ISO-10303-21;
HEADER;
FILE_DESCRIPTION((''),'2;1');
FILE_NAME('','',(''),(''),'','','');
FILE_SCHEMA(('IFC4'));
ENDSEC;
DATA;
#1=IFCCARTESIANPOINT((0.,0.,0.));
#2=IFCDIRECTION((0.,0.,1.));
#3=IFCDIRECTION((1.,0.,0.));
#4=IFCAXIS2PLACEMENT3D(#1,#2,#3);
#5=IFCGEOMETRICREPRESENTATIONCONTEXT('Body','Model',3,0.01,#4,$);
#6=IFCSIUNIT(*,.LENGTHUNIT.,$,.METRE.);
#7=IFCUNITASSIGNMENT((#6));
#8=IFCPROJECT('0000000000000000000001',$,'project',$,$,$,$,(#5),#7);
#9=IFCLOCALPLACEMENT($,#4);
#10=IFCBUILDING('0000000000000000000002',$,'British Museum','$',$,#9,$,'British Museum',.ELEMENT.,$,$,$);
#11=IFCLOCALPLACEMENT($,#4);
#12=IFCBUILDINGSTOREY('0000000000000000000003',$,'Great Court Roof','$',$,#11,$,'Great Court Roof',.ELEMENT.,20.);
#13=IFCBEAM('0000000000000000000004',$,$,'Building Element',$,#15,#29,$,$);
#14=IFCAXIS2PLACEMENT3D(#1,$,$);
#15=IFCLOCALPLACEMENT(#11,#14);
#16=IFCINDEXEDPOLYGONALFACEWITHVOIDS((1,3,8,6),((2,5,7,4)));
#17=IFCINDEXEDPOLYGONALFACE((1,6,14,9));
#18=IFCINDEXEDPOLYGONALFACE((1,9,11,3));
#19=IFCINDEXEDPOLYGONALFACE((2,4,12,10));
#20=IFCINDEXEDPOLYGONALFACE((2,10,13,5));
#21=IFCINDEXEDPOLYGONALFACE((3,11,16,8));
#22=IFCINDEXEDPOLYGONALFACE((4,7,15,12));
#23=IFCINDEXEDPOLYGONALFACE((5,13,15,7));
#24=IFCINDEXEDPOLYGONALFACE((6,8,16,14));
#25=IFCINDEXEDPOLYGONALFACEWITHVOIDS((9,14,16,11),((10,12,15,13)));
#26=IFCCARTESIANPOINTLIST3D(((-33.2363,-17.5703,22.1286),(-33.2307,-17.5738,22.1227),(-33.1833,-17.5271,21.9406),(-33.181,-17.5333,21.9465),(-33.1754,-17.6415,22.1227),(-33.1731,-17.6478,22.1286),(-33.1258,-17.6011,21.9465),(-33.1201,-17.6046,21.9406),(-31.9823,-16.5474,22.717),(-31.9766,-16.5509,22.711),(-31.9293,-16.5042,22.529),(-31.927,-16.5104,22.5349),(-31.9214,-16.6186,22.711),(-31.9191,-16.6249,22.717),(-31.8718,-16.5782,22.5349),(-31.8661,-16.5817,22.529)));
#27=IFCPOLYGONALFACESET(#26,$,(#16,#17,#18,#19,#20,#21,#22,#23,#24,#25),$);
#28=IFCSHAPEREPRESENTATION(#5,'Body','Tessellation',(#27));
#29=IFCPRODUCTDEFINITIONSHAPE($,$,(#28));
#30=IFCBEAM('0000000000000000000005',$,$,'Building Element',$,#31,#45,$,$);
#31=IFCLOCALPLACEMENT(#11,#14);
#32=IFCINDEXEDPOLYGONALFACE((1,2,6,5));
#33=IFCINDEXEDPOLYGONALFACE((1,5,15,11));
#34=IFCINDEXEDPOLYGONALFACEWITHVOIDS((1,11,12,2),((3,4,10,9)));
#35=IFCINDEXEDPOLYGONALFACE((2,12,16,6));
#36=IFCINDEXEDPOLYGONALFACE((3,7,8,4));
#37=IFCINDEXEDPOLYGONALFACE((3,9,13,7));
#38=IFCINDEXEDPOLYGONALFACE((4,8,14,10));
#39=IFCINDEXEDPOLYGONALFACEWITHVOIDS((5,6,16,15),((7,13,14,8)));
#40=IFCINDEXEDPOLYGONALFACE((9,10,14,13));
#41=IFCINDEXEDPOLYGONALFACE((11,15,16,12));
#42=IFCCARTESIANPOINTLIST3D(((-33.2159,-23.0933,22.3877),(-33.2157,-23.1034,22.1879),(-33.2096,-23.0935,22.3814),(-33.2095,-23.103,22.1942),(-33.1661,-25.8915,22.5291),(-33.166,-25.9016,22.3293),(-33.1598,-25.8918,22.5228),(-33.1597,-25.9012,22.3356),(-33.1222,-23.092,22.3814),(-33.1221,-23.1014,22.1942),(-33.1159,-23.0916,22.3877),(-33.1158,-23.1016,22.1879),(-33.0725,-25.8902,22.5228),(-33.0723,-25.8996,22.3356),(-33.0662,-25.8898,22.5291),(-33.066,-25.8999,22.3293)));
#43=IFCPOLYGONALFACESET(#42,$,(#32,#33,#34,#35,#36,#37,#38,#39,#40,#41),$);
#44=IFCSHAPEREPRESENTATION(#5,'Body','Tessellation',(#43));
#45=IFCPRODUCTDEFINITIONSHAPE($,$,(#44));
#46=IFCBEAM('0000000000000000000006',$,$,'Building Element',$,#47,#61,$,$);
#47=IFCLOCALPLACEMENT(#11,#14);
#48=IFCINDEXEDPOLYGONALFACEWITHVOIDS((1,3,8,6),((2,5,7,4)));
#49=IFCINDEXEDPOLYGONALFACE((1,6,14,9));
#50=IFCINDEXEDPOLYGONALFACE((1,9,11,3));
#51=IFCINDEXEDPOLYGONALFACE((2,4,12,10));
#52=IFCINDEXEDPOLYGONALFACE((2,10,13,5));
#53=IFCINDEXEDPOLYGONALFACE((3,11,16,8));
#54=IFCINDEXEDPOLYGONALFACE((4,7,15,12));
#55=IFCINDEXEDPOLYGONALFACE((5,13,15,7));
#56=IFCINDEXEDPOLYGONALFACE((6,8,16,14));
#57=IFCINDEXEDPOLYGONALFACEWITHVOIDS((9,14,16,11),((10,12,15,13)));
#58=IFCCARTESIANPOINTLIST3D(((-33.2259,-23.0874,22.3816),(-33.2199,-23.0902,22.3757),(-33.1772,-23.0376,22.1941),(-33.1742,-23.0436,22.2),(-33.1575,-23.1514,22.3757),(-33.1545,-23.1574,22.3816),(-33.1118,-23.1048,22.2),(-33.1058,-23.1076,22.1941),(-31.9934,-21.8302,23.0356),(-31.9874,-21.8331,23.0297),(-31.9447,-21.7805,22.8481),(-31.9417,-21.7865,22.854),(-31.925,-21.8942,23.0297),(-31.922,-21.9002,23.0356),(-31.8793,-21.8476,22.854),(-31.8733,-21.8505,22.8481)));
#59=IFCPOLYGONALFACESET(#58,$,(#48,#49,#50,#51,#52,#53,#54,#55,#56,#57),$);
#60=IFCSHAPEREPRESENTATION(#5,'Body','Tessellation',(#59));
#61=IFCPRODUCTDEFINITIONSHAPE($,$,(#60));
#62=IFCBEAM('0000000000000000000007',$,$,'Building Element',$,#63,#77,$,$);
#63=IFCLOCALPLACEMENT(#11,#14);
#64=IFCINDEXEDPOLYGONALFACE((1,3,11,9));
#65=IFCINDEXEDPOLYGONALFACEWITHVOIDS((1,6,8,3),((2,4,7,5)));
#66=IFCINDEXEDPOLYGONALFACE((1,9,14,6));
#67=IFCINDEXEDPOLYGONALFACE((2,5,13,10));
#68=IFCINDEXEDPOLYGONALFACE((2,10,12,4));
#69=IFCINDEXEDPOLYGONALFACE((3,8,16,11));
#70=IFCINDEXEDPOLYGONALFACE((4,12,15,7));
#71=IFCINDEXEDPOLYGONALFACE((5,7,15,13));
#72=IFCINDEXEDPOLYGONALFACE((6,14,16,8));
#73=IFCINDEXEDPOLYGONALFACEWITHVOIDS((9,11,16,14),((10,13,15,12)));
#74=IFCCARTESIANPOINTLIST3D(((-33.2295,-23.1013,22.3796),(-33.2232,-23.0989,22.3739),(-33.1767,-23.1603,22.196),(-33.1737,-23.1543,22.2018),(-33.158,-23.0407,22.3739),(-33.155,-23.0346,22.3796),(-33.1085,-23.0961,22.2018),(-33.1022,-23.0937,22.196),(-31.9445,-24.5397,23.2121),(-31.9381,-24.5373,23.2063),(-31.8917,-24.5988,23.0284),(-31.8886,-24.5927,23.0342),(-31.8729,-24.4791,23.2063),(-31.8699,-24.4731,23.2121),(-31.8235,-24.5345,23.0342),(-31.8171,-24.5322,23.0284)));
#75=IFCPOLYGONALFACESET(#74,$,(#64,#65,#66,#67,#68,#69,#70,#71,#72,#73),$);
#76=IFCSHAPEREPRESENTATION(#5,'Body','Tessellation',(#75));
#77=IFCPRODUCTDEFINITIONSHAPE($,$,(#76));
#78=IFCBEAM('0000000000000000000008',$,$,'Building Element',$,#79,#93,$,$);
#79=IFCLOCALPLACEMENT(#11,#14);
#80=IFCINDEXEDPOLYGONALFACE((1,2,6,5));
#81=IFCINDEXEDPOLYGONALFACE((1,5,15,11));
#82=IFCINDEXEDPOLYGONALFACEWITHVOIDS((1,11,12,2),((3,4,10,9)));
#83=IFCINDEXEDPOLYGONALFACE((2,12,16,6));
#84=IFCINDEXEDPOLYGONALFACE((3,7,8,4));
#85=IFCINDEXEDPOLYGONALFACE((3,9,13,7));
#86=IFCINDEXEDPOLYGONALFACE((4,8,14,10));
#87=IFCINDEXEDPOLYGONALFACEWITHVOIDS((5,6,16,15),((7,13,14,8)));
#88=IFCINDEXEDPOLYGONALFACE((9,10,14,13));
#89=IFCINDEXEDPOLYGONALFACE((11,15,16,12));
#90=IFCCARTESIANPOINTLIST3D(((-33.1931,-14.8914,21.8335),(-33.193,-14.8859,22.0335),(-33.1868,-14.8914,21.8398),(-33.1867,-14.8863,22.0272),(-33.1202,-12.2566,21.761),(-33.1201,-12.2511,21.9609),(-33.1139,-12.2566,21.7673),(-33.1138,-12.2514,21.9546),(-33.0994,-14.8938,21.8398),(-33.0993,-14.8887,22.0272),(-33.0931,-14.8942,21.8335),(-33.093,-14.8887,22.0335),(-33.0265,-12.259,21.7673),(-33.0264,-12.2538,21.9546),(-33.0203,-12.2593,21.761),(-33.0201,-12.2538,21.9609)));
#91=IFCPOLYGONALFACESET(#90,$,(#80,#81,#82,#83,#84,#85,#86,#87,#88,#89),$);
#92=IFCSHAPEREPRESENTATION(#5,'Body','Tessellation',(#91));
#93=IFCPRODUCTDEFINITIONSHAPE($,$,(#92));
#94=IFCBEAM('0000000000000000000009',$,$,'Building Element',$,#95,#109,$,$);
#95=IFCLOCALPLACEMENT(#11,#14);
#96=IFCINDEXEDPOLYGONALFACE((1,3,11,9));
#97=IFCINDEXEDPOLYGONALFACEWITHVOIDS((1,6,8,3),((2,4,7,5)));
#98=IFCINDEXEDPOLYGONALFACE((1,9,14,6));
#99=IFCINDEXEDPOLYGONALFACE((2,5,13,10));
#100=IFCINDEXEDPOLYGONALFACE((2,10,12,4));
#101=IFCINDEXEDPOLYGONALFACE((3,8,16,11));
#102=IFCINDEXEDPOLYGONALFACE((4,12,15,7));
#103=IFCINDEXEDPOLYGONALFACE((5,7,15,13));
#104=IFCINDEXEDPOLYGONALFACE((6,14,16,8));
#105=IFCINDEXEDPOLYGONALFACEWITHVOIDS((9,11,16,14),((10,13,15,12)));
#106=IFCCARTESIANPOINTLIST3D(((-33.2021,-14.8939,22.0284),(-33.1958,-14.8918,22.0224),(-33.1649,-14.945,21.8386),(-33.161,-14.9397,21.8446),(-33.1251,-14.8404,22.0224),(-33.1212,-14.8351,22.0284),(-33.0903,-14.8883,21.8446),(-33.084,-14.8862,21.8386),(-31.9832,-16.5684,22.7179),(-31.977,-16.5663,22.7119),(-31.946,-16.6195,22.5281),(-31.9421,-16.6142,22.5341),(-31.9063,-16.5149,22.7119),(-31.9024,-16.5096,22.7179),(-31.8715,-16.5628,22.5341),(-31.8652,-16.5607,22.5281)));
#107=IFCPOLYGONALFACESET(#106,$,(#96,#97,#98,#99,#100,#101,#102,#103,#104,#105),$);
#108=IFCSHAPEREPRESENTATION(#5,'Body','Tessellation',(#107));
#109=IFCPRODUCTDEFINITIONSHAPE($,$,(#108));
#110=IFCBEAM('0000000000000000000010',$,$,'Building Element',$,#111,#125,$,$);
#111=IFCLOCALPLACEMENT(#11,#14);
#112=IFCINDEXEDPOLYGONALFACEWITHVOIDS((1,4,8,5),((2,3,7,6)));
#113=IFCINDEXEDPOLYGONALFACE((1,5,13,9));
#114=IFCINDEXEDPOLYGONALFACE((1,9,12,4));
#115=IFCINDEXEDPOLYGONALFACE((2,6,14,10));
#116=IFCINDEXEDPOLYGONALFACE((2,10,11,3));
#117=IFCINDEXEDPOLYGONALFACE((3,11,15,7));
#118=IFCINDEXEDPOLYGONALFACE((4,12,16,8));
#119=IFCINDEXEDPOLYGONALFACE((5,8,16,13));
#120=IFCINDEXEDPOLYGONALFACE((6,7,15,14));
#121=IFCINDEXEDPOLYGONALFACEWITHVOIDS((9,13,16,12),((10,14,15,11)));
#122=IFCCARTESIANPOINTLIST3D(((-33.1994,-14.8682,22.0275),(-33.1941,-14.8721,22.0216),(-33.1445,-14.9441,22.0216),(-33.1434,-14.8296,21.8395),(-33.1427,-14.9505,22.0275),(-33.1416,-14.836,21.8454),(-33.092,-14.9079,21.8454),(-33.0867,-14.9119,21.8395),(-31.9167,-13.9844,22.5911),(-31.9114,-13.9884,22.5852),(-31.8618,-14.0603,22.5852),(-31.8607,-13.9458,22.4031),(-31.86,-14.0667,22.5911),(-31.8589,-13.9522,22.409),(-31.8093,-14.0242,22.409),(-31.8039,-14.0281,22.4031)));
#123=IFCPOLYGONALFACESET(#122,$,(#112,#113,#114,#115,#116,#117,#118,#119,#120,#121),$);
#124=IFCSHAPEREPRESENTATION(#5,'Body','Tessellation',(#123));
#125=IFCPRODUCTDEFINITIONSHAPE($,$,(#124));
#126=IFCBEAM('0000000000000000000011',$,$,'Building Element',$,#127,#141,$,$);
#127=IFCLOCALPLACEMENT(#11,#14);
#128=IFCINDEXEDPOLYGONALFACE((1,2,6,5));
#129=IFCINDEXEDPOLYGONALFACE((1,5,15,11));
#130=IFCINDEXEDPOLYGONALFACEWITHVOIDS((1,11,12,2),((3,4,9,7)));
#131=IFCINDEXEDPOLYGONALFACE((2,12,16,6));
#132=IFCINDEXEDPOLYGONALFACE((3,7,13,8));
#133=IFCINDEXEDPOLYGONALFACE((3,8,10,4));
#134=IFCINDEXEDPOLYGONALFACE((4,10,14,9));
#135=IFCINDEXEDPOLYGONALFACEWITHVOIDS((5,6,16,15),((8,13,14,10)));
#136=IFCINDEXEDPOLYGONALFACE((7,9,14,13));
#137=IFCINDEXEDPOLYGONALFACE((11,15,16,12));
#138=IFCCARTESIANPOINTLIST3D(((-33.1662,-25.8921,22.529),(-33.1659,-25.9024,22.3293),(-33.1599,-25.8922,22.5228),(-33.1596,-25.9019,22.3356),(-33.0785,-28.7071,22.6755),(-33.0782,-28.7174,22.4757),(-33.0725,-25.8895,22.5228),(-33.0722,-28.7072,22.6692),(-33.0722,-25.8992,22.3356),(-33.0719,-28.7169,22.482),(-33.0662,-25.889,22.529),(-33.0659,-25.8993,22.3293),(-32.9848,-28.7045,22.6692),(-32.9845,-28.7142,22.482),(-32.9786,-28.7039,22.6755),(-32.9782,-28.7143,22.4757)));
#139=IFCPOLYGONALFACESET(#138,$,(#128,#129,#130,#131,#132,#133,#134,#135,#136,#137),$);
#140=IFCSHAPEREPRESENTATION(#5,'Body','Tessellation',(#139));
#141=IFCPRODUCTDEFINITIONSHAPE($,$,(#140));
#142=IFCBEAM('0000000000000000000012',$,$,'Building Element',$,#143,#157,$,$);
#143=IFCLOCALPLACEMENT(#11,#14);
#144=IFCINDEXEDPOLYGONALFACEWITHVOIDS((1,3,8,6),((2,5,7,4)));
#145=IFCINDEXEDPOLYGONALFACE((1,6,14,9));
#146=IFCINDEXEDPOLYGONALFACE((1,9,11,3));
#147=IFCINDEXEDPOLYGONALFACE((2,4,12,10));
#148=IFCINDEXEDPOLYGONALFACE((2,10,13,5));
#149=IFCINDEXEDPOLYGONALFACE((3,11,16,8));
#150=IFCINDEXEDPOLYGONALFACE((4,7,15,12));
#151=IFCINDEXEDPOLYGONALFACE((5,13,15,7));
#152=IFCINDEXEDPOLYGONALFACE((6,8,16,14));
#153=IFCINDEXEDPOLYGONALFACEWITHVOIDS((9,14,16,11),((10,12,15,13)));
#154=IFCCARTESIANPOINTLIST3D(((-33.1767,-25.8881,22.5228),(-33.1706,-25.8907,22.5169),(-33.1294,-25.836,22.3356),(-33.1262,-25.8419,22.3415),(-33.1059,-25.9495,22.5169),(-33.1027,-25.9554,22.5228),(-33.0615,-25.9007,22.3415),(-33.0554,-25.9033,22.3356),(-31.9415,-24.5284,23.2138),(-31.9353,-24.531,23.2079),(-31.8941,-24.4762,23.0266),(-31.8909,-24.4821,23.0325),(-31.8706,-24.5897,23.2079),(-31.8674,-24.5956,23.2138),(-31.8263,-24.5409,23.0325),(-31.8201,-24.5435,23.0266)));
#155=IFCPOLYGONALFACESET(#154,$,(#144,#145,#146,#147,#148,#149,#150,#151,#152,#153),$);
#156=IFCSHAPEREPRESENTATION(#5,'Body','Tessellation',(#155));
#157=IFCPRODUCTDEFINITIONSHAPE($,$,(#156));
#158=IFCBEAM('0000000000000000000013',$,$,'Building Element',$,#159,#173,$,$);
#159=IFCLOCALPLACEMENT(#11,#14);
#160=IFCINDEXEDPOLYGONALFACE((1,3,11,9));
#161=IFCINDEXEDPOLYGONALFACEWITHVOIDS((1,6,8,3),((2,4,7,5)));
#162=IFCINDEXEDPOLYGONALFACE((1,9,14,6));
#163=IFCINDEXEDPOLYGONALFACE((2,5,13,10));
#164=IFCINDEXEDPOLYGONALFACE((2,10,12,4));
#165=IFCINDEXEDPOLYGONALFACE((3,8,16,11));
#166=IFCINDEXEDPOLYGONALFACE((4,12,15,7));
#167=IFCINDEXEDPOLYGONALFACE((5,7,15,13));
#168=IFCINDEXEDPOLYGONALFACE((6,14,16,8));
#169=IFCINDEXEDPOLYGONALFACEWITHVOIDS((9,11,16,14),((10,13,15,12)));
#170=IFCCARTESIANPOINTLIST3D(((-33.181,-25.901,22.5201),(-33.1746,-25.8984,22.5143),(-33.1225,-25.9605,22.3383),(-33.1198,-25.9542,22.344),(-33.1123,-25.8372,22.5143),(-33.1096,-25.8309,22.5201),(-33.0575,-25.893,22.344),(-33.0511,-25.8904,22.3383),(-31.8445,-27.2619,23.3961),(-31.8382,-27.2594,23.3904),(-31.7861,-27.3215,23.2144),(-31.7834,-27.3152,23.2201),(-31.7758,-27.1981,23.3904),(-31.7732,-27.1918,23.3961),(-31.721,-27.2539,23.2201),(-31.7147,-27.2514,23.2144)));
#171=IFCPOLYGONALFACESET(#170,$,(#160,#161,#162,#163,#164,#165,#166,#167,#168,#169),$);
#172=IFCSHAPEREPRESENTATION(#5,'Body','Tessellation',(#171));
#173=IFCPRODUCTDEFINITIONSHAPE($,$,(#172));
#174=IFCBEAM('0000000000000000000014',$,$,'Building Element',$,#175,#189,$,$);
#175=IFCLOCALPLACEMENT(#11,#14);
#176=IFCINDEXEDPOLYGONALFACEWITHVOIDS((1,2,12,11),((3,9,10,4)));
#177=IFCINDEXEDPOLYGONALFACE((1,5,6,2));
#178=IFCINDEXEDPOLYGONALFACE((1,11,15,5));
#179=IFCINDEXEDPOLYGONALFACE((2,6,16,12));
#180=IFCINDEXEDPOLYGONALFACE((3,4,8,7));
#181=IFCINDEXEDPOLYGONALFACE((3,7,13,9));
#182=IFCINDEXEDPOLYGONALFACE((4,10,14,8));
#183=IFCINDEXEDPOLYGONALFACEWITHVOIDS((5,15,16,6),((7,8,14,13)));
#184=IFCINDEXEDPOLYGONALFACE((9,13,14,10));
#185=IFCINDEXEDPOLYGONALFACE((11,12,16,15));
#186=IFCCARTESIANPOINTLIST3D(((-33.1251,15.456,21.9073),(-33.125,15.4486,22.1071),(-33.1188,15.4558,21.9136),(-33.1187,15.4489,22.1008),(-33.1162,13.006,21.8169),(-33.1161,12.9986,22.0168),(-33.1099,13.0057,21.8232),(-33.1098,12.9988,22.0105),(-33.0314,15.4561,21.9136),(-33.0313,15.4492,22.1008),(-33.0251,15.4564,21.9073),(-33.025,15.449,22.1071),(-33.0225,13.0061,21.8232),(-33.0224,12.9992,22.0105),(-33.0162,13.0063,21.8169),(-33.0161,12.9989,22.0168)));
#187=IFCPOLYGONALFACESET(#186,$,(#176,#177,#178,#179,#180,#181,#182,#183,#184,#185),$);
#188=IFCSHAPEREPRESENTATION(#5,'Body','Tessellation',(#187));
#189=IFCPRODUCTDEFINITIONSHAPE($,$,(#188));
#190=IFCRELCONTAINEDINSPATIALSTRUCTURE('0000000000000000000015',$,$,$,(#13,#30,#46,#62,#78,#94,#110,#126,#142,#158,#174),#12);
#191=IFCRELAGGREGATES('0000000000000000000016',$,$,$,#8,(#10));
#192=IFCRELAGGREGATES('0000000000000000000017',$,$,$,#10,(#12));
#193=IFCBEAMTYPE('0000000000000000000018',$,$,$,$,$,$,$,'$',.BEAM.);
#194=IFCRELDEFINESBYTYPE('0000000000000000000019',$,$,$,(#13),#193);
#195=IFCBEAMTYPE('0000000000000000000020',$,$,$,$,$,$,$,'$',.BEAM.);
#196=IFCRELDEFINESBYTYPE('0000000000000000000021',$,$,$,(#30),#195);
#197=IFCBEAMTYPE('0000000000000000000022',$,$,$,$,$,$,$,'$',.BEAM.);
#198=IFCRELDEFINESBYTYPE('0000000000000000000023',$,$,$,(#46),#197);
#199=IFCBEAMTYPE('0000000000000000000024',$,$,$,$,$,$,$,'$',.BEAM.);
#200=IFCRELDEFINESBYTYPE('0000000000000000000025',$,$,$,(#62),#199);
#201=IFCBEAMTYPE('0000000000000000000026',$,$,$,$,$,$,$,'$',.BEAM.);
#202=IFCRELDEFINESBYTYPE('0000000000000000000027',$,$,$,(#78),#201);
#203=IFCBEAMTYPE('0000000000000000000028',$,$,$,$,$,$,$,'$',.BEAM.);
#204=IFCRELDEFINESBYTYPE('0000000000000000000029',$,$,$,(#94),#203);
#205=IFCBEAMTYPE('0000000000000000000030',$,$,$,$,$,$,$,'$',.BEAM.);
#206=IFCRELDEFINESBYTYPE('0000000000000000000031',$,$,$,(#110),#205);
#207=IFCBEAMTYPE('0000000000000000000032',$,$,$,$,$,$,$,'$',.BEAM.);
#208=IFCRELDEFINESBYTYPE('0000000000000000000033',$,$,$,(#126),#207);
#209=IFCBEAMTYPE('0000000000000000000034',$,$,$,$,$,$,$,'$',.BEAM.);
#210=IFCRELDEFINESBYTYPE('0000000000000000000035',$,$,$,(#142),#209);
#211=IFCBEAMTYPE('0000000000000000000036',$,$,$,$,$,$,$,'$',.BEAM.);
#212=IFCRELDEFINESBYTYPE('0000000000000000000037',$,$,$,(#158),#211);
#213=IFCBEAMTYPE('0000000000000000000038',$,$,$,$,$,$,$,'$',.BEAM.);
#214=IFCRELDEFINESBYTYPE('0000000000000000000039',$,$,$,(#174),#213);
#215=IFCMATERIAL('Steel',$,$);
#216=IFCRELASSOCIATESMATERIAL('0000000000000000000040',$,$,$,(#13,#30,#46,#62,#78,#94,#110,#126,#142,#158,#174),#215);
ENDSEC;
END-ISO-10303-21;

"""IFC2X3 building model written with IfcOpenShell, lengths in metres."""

from ifc_helpers import new_model, si_unit, frame, origin_with_axes, origin_2d, place, context, project, spatial, hollow_rectangle, extrude, material, type_object, element, save


model = new_model("IFC2X3")

# Units and contexts
model_context = context("Model", 3, precision=0.01, world=origin_with_axes(), identifier="Body")
ifc_project = project(units=[si_unit("LENGTHUNIT", "METRE")], contexts=[model_context])

# Building, storey
building_placement = place(None, origin_with_axes())
building = spatial("IfcBuilding", under=ifc_project, at=building_placement, Name="British Museum", Description="$", LongName="British Museum", CompositionType="ELEMENT")
storey_placement = place(None, origin_with_axes())
storey = spatial("IfcBuildingStorey", under=building, at=storey_placement, Name="Great Court Roof", Description="$", LongName="Great Court Roof", CompositionType="ELEMENT", Elevation=20.0)

# Beams
ifc_material = material(Name="Steel")
beam_type_1 = type_object("IfcBeamType", ElementType="$", PredefinedType="BEAM")
beam_1_placement = place(None, origin_with_axes())
element("IfcBeam", 1, at=beam_1_placement, inside=storey, type_object=beam_type_1, material=ifc_material, Description="Building Element", context=model_context, shape_type="SweptSolid", body=[
    extrude(hollow_rectangle(XDim=0.1, YDim=0.2, WallThickness=0.0063, InnerFilletRadius=0.0, OuterFilletRadius=0.0, at=origin_2d()), frame((-33.1782, -17.5874, 22.0346), z_axis=(0.728256, 0.594044, 0.341693), x_axis=(-0.632089, 0.774896, 0.0)), (0.0, 0.0, 1.0), 1.7219),
])
beam_type_2 = type_object("IfcBeamType", ElementType="$", PredefinedType="BEAM")
beam_2_placement = place(None, origin_with_axes())
element("IfcBeam", 2, at=beam_2_placement, inside=storey, type_object=beam_type_2, material=ifc_material, Description="Building Element", context=model_context, shape_type="SweptSolid", body=[
    extrude(hollow_rectangle(XDim=0.1, YDim=0.2, WallThickness=0.0063, InnerFilletRadius=0.0, OuterFilletRadius=0.0, at=origin_2d()), frame((-33.1658, -23.0975, 22.2878), z_axis=(0.017765, -0.998569, 0.050446), x_axis=(0.999842, 0.017788, 0.0)), (0.0, 0.0, 1.0), 2.8022),
])
beam_type_3 = type_object("IfcBeamType", ElementType="$", PredefinedType="BEAM")
beam_3_placement = place(None, origin_with_axes())
element("IfcBeam", 3, at=beam_3_placement, inside=storey, type_object=beam_type_3, material=ifc_material, Description="Building Element", context=model_context, shape_type="SweptSolid", body=[
    extrude(hollow_rectangle(XDim=0.1, YDim=0.2, WallThickness=0.0063, InnerFilletRadius=0.0, OuterFilletRadius=0.0, at=origin_2d()), frame((-33.1658, -23.0975, 22.2878), z_axis=(0.656247, 0.669371, 0.348256), x_axis=(-0.714072, 0.700072, 0.0)), (0.0, 0.0, 1.0), 1.8781),
])
beam_type_4 = type_object("IfcBeamType", ElementType="$", PredefinedType="BEAM")
beam_4_placement = place(None, origin_with_axes())
element("IfcBeam", 4, at=beam_4_placement, inside=storey, type_object=beam_type_4, material=ifc_material, Description="Building Element", context=model_context, shape_type="SweptSolid", body=[
    extrude(hollow_rectangle(XDim=0.1, YDim=0.2, WallThickness=0.0063, InnerFilletRadius=0.0, OuterFilletRadius=0.0, at=origin_2d()), frame((-33.1658, -23.0975, 22.2878), z_axis=(0.611699, -0.684703, 0.396239), x_axis=(0.745745, 0.666232, 0.0)), (0.0, 0.0, 1.0), 2.1008),
])
beam_type_5 = type_object("IfcBeamType", ElementType="$", PredefinedType="BEAM")
beam_5_placement = place(None, origin_with_axes())
element("IfcBeam", 5, at=beam_5_placement, inside=storey, type_object=beam_type_5, material=ifc_material, Description="Building Element", context=model_context, shape_type="SweptSolid", body=[
    extrude(hollow_rectangle(XDim=0.1, YDim=0.2, WallThickness=0.0063, InnerFilletRadius=0.0, OuterFilletRadius=0.0, at=origin_2d()), frame((-33.143, -14.89, 21.9335), z_axis=(0.027642, 0.999239, -0.027509), x_axis=(-0.999618, 0.027652, 0.0)), (0.0, 0.0, 1.0), 2.6369),
])
beam_type_6 = type_object("IfcBeamType", ElementType="$", PredefinedType="BEAM")
beam_6_placement = place(None, origin_with_axes())
element("IfcBeam", 6, at=beam_6_placement, inside=storey, type_object=beam_type_6, material=ifc_material, Description="Building Element", context=model_context, shape_type="SweptSolid", body=[
    extrude(hollow_rectangle(XDim=0.1, YDim=0.2, WallThickness=0.0063, InnerFilletRadius=0.0, OuterFilletRadius=0.0, at=origin_2d()), frame((-33.143, -14.89, 21.9335), z_axis=(0.558367, -0.767113, 0.315856), x_axis=(0.808502, 0.588493, 0.0)), (0.0, 0.0, 1.0), 2.1829),
])
beam_type_7 = type_object("IfcBeamType", ElementType="$", PredefinedType="BEAM")
beam_7_placement = place(None, origin_with_axes())
element("IfcBeam", 7, at=beam_7_placement, inside=storey, type_object=beam_type_7, material=ifc_material, Description="Building Element", context=model_context, shape_type="SweptSolid", body=[
    extrude(hollow_rectangle(XDim=0.1, YDim=0.2, WallThickness=0.0063, InnerFilletRadius=0.0, OuterFilletRadius=0.0, at=origin_2d()), frame((-33.143, -14.89, 21.9335), z_axis=(0.774351, 0.53351, 0.340216), x_axis=(-0.567355, 0.823474, 0.0)), (0.0, 0.0, 1.0), 1.6565),
])
beam_type_8 = type_object("IfcBeamType", ElementType="$", PredefinedType="BEAM")
beam_8_placement = place(None, origin_with_axes())
element("IfcBeam", 8, at=beam_8_placement, inside=storey, type_object=beam_type_8, material=ifc_material, Description="Building Element", context=model_context, shape_type="SweptSolid", body=[
    extrude(hollow_rectangle(XDim=0.1, YDim=0.2, WallThickness=0.0063, InnerFilletRadius=0.0, OuterFilletRadius=0.0, at=origin_2d()), frame((-33.1161, -25.8957, 22.4292), z_axis=(0.031096, -0.998167, 0.051915), x_axis=(0.999515, 0.031138, 0.0)), (0.0, 0.0, 1.0), 2.8202),
])
beam_type_9 = type_object("IfcBeamType", ElementType="$", PredefinedType="BEAM")
beam_9_placement = place(None, origin_with_axes())
element("IfcBeam", 9, at=beam_9_placement, inside=storey, type_object=beam_type_9, material=ifc_material, Description="Building Element", context=model_context, shape_type="SweptSolid", body=[
    extrude(hollow_rectangle(XDim=0.1, YDim=0.2, WallThickness=0.0063, InnerFilletRadius=0.0, OuterFilletRadius=0.0, at=origin_2d()), frame((-33.1161, -25.8957, 22.4292), z_axis=(0.629355, 0.692783, 0.352084), x_axis=(-0.740178, 0.672411, 0.0)), (0.0, 0.0, 1.0), 1.9628),
])
beam_type_10 = type_object("IfcBeamType", ElementType="$", PredefinedType="BEAM")
beam_10_placement = place(None, origin_with_axes())
element("IfcBeam", 10, at=beam_10_placement, inside=storey, type_object=beam_type_10, material=ifc_material, Description="Building Element", context=model_context, shape_type="SweptSolid", body=[
    extrude(hollow_rectangle(XDim=0.1, YDim=0.2, WallThickness=0.0063, InnerFilletRadius=0.0, OuterFilletRadius=0.0, at=origin_2d()), frame((-33.1161, -25.8957, 22.4292), z_axis=(0.636709, -0.648385, 0.41737), x_axis=(0.713502, 0.700653, 0.0)), (0.0, 0.0, 1.0), 2.099),
])
beam_type_11 = type_object("IfcBeamType", ElementType="$", PredefinedType="BEAM")
beam_11_placement = place(None, origin_with_axes())
element("IfcBeam", 11, at=beam_11_placement, inside=storey, type_object=beam_type_11, material=ifc_material, Description="Building Element", context=model_context, shape_type="SweptSolid", body=[
    extrude(hollow_rectangle(XDim=0.1, YDim=0.2, WallThickness=0.0063, InnerFilletRadius=0.0, OuterFilletRadius=0.0, at=origin_2d()), frame((-33.0751, 15.4525, 22.0072), z_axis=(0.00363, -0.999314, -0.036854), x_axis=(0.999993, 0.003633, 0.0)), (0.0, 0.0, 1.0), 2.4517),
])

save(model, "model.ifc")
